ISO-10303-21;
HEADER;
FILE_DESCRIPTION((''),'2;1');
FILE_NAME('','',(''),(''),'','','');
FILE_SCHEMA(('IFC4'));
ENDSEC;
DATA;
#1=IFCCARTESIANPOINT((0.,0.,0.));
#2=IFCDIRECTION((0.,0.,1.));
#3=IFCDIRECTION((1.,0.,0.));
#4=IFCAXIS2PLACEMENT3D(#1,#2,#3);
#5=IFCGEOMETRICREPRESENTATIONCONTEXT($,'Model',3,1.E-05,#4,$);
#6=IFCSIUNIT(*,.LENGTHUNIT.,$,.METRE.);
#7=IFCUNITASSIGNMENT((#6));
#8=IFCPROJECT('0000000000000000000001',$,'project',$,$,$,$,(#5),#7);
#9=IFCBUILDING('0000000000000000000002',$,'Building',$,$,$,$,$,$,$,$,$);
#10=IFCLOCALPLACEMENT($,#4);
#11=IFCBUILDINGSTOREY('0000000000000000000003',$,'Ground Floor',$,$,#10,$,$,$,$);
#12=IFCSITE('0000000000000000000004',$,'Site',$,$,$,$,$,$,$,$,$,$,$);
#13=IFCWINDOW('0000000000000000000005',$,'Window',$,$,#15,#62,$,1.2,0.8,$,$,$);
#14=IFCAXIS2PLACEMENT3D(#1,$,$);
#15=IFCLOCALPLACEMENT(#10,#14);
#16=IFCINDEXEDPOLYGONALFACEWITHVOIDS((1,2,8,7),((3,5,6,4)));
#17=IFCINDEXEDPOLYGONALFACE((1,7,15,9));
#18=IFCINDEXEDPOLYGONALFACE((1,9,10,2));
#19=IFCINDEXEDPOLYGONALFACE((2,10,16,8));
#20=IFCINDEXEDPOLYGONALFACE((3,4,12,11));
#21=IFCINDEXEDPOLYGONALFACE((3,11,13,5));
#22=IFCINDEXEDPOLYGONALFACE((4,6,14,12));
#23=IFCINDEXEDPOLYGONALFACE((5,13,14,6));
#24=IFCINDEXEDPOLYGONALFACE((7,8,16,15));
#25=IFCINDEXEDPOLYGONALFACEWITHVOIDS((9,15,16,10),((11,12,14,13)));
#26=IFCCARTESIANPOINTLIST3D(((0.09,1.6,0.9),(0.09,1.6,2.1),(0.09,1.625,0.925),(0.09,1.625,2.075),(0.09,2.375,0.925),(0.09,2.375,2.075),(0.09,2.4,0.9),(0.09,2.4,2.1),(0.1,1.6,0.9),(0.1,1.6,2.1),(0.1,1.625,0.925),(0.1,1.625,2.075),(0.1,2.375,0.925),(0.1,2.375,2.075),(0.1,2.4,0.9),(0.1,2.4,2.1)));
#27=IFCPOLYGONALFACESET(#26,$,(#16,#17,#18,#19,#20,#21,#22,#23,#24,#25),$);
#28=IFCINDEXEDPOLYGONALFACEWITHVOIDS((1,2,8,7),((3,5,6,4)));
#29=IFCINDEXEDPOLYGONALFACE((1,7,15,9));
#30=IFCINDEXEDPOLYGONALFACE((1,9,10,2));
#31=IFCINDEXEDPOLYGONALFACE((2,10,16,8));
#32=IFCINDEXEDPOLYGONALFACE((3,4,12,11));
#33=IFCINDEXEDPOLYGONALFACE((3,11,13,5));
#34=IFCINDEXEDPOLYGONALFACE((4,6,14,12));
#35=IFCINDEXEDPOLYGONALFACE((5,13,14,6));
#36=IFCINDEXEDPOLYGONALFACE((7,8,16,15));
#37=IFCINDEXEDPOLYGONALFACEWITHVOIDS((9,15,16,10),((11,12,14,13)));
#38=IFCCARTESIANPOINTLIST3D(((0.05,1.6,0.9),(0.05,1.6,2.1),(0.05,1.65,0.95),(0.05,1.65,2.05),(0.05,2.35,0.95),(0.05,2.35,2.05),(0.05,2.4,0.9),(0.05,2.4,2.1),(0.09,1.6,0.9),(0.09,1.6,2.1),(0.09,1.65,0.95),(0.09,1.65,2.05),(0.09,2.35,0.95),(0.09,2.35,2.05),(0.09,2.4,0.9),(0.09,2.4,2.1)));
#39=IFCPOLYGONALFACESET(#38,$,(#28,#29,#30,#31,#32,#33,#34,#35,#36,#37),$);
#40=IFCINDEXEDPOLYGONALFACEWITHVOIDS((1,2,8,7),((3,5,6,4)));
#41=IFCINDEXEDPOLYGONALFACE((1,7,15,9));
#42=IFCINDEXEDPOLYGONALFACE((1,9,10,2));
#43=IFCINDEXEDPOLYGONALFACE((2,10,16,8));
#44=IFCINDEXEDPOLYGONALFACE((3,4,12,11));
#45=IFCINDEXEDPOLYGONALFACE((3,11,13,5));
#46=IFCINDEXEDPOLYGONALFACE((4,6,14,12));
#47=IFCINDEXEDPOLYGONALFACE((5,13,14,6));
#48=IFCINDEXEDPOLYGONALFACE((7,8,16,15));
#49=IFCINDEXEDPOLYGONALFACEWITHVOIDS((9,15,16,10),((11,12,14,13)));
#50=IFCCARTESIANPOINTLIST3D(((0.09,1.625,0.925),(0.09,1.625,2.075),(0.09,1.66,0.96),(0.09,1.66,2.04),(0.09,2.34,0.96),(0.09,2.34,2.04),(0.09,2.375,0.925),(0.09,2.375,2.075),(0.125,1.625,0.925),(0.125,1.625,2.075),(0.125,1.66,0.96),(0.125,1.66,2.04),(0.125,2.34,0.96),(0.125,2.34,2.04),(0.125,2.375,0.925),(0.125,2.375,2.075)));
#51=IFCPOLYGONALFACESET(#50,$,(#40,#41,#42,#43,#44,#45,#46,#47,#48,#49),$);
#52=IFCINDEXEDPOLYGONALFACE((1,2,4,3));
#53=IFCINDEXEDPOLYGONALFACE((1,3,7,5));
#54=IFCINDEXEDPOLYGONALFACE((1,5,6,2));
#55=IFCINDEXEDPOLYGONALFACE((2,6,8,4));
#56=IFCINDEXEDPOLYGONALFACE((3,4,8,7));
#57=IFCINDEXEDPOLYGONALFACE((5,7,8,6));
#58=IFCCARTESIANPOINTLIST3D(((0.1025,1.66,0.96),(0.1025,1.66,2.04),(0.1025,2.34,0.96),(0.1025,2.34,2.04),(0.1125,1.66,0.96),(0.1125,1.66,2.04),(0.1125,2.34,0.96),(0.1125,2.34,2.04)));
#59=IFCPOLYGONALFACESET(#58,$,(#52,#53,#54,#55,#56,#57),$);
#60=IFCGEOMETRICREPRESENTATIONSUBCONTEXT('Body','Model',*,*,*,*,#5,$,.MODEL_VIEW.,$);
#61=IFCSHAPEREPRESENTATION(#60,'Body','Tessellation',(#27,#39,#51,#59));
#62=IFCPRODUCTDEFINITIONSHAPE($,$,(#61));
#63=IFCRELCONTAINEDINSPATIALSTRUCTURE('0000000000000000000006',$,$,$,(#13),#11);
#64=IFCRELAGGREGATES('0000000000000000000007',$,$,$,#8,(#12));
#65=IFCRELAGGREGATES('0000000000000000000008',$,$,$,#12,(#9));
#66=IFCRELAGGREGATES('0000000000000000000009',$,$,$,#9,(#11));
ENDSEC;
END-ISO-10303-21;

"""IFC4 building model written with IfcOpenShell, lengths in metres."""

from ifc_helpers import new_model, si_unit, frame, origin_with_axes, place, context, subcontext, project, spatial, line, indexed_curve, outline, extrude, element, save


model = new_model("IFC4")

# Units and contexts
model_context = context("Model", 3, precision=1e-05, world=origin_with_axes())
body_context = subcontext(model_context, "Body", "Model", "MODEL_VIEW")
ifc_project = project(units=[si_unit("LENGTHUNIT", "METRE")], contexts=[model_context])

# Site, building, storey
site = spatial("IfcSite", under=ifc_project, Name="Site")
building = spatial("IfcBuilding", under=site, Name="Building")
storey_placement = place(None, origin_with_axes())
storey = spatial("IfcBuildingStorey", under=building, at=storey_placement, Name="Ground Floor")

# Window
window_1_placement = place(storey_placement, frame((0.0, 2.4, 0.9), z_axis=(0.0, 0.0, 1.0), x_axis=(0.0, -1.0, 0.0)))
element("IfcWindow", 1, at=window_1_placement, inside=storey, Name="Window", OverallHeight=1.2, OverallWidth=0.8, context=body_context, shape_type="SweptSolid", body=[
    extrude(outline(indexed_curve([(0.0, 0.0), (0.8, 0.0), (0.8, 1.2), (0.0, 1.2)], segments=[line(1, 2, 3, 4, 1)]), holes=[indexed_curve([(0.025, 0.025), (0.775, 0.025), (0.775, 1.175), (0.025, 1.175)], segments=[line(1, 2, 3, 4, 1)])]), frame((0.0, 0.09, 0.0), z_axis=(0.0, -1.0, 0.0), x_axis=(1.0, 0.0, 0.0)), (0.0, 0.0, -1.0), 0.01),
    extrude(outline(indexed_curve([(0.0, 0.0), (0.8, 0.0), (0.8, 1.2), (0.0, 1.2)], segments=[line(1, 2, 3, 4, 1)]), holes=[indexed_curve([(0.05, 0.05), (0.75, 0.05), (0.75, 1.15), (0.05, 1.15)], segments=[line(1, 2, 3, 4, 1)])]), frame((0.0, 0.05, 0.0), z_axis=(0.0, -1.0, 0.0), x_axis=(1.0, 0.0, 0.0)), (0.0, 0.0, -1.0), 0.04),
    extrude(outline(indexed_curve([(0.0, 0.0), (0.75, 0.0), (0.75, 1.15), (0.0, 1.15)], segments=[line(1, 2, 3, 4, 1)]), holes=[indexed_curve([(0.035, 0.035), (0.715, 0.035), (0.715, 1.115), (0.035, 1.115)], segments=[line(1, 2, 3, 4, 1)])]), frame((0.025, 0.09, 0.025), z_axis=(0.0, -1.0, 0.0), x_axis=(1.0, 0.0, 0.0)), (0.0, 0.0, -1.0), 0.035),
    extrude(outline(indexed_curve([(0.035, 0.035), (0.715, 0.035), (0.715, 1.115), (0.035, 1.115)], segments=[line(1, 2, 3, 4, 1)])), frame((0.025, 0.1025, 0.025), z_axis=(0.0, -1.0, 0.0), x_axis=(1.0, 0.0, 0.0)), (0.0, 0.0, -1.0), 0.01),
])

save(model, "model.ifc")
